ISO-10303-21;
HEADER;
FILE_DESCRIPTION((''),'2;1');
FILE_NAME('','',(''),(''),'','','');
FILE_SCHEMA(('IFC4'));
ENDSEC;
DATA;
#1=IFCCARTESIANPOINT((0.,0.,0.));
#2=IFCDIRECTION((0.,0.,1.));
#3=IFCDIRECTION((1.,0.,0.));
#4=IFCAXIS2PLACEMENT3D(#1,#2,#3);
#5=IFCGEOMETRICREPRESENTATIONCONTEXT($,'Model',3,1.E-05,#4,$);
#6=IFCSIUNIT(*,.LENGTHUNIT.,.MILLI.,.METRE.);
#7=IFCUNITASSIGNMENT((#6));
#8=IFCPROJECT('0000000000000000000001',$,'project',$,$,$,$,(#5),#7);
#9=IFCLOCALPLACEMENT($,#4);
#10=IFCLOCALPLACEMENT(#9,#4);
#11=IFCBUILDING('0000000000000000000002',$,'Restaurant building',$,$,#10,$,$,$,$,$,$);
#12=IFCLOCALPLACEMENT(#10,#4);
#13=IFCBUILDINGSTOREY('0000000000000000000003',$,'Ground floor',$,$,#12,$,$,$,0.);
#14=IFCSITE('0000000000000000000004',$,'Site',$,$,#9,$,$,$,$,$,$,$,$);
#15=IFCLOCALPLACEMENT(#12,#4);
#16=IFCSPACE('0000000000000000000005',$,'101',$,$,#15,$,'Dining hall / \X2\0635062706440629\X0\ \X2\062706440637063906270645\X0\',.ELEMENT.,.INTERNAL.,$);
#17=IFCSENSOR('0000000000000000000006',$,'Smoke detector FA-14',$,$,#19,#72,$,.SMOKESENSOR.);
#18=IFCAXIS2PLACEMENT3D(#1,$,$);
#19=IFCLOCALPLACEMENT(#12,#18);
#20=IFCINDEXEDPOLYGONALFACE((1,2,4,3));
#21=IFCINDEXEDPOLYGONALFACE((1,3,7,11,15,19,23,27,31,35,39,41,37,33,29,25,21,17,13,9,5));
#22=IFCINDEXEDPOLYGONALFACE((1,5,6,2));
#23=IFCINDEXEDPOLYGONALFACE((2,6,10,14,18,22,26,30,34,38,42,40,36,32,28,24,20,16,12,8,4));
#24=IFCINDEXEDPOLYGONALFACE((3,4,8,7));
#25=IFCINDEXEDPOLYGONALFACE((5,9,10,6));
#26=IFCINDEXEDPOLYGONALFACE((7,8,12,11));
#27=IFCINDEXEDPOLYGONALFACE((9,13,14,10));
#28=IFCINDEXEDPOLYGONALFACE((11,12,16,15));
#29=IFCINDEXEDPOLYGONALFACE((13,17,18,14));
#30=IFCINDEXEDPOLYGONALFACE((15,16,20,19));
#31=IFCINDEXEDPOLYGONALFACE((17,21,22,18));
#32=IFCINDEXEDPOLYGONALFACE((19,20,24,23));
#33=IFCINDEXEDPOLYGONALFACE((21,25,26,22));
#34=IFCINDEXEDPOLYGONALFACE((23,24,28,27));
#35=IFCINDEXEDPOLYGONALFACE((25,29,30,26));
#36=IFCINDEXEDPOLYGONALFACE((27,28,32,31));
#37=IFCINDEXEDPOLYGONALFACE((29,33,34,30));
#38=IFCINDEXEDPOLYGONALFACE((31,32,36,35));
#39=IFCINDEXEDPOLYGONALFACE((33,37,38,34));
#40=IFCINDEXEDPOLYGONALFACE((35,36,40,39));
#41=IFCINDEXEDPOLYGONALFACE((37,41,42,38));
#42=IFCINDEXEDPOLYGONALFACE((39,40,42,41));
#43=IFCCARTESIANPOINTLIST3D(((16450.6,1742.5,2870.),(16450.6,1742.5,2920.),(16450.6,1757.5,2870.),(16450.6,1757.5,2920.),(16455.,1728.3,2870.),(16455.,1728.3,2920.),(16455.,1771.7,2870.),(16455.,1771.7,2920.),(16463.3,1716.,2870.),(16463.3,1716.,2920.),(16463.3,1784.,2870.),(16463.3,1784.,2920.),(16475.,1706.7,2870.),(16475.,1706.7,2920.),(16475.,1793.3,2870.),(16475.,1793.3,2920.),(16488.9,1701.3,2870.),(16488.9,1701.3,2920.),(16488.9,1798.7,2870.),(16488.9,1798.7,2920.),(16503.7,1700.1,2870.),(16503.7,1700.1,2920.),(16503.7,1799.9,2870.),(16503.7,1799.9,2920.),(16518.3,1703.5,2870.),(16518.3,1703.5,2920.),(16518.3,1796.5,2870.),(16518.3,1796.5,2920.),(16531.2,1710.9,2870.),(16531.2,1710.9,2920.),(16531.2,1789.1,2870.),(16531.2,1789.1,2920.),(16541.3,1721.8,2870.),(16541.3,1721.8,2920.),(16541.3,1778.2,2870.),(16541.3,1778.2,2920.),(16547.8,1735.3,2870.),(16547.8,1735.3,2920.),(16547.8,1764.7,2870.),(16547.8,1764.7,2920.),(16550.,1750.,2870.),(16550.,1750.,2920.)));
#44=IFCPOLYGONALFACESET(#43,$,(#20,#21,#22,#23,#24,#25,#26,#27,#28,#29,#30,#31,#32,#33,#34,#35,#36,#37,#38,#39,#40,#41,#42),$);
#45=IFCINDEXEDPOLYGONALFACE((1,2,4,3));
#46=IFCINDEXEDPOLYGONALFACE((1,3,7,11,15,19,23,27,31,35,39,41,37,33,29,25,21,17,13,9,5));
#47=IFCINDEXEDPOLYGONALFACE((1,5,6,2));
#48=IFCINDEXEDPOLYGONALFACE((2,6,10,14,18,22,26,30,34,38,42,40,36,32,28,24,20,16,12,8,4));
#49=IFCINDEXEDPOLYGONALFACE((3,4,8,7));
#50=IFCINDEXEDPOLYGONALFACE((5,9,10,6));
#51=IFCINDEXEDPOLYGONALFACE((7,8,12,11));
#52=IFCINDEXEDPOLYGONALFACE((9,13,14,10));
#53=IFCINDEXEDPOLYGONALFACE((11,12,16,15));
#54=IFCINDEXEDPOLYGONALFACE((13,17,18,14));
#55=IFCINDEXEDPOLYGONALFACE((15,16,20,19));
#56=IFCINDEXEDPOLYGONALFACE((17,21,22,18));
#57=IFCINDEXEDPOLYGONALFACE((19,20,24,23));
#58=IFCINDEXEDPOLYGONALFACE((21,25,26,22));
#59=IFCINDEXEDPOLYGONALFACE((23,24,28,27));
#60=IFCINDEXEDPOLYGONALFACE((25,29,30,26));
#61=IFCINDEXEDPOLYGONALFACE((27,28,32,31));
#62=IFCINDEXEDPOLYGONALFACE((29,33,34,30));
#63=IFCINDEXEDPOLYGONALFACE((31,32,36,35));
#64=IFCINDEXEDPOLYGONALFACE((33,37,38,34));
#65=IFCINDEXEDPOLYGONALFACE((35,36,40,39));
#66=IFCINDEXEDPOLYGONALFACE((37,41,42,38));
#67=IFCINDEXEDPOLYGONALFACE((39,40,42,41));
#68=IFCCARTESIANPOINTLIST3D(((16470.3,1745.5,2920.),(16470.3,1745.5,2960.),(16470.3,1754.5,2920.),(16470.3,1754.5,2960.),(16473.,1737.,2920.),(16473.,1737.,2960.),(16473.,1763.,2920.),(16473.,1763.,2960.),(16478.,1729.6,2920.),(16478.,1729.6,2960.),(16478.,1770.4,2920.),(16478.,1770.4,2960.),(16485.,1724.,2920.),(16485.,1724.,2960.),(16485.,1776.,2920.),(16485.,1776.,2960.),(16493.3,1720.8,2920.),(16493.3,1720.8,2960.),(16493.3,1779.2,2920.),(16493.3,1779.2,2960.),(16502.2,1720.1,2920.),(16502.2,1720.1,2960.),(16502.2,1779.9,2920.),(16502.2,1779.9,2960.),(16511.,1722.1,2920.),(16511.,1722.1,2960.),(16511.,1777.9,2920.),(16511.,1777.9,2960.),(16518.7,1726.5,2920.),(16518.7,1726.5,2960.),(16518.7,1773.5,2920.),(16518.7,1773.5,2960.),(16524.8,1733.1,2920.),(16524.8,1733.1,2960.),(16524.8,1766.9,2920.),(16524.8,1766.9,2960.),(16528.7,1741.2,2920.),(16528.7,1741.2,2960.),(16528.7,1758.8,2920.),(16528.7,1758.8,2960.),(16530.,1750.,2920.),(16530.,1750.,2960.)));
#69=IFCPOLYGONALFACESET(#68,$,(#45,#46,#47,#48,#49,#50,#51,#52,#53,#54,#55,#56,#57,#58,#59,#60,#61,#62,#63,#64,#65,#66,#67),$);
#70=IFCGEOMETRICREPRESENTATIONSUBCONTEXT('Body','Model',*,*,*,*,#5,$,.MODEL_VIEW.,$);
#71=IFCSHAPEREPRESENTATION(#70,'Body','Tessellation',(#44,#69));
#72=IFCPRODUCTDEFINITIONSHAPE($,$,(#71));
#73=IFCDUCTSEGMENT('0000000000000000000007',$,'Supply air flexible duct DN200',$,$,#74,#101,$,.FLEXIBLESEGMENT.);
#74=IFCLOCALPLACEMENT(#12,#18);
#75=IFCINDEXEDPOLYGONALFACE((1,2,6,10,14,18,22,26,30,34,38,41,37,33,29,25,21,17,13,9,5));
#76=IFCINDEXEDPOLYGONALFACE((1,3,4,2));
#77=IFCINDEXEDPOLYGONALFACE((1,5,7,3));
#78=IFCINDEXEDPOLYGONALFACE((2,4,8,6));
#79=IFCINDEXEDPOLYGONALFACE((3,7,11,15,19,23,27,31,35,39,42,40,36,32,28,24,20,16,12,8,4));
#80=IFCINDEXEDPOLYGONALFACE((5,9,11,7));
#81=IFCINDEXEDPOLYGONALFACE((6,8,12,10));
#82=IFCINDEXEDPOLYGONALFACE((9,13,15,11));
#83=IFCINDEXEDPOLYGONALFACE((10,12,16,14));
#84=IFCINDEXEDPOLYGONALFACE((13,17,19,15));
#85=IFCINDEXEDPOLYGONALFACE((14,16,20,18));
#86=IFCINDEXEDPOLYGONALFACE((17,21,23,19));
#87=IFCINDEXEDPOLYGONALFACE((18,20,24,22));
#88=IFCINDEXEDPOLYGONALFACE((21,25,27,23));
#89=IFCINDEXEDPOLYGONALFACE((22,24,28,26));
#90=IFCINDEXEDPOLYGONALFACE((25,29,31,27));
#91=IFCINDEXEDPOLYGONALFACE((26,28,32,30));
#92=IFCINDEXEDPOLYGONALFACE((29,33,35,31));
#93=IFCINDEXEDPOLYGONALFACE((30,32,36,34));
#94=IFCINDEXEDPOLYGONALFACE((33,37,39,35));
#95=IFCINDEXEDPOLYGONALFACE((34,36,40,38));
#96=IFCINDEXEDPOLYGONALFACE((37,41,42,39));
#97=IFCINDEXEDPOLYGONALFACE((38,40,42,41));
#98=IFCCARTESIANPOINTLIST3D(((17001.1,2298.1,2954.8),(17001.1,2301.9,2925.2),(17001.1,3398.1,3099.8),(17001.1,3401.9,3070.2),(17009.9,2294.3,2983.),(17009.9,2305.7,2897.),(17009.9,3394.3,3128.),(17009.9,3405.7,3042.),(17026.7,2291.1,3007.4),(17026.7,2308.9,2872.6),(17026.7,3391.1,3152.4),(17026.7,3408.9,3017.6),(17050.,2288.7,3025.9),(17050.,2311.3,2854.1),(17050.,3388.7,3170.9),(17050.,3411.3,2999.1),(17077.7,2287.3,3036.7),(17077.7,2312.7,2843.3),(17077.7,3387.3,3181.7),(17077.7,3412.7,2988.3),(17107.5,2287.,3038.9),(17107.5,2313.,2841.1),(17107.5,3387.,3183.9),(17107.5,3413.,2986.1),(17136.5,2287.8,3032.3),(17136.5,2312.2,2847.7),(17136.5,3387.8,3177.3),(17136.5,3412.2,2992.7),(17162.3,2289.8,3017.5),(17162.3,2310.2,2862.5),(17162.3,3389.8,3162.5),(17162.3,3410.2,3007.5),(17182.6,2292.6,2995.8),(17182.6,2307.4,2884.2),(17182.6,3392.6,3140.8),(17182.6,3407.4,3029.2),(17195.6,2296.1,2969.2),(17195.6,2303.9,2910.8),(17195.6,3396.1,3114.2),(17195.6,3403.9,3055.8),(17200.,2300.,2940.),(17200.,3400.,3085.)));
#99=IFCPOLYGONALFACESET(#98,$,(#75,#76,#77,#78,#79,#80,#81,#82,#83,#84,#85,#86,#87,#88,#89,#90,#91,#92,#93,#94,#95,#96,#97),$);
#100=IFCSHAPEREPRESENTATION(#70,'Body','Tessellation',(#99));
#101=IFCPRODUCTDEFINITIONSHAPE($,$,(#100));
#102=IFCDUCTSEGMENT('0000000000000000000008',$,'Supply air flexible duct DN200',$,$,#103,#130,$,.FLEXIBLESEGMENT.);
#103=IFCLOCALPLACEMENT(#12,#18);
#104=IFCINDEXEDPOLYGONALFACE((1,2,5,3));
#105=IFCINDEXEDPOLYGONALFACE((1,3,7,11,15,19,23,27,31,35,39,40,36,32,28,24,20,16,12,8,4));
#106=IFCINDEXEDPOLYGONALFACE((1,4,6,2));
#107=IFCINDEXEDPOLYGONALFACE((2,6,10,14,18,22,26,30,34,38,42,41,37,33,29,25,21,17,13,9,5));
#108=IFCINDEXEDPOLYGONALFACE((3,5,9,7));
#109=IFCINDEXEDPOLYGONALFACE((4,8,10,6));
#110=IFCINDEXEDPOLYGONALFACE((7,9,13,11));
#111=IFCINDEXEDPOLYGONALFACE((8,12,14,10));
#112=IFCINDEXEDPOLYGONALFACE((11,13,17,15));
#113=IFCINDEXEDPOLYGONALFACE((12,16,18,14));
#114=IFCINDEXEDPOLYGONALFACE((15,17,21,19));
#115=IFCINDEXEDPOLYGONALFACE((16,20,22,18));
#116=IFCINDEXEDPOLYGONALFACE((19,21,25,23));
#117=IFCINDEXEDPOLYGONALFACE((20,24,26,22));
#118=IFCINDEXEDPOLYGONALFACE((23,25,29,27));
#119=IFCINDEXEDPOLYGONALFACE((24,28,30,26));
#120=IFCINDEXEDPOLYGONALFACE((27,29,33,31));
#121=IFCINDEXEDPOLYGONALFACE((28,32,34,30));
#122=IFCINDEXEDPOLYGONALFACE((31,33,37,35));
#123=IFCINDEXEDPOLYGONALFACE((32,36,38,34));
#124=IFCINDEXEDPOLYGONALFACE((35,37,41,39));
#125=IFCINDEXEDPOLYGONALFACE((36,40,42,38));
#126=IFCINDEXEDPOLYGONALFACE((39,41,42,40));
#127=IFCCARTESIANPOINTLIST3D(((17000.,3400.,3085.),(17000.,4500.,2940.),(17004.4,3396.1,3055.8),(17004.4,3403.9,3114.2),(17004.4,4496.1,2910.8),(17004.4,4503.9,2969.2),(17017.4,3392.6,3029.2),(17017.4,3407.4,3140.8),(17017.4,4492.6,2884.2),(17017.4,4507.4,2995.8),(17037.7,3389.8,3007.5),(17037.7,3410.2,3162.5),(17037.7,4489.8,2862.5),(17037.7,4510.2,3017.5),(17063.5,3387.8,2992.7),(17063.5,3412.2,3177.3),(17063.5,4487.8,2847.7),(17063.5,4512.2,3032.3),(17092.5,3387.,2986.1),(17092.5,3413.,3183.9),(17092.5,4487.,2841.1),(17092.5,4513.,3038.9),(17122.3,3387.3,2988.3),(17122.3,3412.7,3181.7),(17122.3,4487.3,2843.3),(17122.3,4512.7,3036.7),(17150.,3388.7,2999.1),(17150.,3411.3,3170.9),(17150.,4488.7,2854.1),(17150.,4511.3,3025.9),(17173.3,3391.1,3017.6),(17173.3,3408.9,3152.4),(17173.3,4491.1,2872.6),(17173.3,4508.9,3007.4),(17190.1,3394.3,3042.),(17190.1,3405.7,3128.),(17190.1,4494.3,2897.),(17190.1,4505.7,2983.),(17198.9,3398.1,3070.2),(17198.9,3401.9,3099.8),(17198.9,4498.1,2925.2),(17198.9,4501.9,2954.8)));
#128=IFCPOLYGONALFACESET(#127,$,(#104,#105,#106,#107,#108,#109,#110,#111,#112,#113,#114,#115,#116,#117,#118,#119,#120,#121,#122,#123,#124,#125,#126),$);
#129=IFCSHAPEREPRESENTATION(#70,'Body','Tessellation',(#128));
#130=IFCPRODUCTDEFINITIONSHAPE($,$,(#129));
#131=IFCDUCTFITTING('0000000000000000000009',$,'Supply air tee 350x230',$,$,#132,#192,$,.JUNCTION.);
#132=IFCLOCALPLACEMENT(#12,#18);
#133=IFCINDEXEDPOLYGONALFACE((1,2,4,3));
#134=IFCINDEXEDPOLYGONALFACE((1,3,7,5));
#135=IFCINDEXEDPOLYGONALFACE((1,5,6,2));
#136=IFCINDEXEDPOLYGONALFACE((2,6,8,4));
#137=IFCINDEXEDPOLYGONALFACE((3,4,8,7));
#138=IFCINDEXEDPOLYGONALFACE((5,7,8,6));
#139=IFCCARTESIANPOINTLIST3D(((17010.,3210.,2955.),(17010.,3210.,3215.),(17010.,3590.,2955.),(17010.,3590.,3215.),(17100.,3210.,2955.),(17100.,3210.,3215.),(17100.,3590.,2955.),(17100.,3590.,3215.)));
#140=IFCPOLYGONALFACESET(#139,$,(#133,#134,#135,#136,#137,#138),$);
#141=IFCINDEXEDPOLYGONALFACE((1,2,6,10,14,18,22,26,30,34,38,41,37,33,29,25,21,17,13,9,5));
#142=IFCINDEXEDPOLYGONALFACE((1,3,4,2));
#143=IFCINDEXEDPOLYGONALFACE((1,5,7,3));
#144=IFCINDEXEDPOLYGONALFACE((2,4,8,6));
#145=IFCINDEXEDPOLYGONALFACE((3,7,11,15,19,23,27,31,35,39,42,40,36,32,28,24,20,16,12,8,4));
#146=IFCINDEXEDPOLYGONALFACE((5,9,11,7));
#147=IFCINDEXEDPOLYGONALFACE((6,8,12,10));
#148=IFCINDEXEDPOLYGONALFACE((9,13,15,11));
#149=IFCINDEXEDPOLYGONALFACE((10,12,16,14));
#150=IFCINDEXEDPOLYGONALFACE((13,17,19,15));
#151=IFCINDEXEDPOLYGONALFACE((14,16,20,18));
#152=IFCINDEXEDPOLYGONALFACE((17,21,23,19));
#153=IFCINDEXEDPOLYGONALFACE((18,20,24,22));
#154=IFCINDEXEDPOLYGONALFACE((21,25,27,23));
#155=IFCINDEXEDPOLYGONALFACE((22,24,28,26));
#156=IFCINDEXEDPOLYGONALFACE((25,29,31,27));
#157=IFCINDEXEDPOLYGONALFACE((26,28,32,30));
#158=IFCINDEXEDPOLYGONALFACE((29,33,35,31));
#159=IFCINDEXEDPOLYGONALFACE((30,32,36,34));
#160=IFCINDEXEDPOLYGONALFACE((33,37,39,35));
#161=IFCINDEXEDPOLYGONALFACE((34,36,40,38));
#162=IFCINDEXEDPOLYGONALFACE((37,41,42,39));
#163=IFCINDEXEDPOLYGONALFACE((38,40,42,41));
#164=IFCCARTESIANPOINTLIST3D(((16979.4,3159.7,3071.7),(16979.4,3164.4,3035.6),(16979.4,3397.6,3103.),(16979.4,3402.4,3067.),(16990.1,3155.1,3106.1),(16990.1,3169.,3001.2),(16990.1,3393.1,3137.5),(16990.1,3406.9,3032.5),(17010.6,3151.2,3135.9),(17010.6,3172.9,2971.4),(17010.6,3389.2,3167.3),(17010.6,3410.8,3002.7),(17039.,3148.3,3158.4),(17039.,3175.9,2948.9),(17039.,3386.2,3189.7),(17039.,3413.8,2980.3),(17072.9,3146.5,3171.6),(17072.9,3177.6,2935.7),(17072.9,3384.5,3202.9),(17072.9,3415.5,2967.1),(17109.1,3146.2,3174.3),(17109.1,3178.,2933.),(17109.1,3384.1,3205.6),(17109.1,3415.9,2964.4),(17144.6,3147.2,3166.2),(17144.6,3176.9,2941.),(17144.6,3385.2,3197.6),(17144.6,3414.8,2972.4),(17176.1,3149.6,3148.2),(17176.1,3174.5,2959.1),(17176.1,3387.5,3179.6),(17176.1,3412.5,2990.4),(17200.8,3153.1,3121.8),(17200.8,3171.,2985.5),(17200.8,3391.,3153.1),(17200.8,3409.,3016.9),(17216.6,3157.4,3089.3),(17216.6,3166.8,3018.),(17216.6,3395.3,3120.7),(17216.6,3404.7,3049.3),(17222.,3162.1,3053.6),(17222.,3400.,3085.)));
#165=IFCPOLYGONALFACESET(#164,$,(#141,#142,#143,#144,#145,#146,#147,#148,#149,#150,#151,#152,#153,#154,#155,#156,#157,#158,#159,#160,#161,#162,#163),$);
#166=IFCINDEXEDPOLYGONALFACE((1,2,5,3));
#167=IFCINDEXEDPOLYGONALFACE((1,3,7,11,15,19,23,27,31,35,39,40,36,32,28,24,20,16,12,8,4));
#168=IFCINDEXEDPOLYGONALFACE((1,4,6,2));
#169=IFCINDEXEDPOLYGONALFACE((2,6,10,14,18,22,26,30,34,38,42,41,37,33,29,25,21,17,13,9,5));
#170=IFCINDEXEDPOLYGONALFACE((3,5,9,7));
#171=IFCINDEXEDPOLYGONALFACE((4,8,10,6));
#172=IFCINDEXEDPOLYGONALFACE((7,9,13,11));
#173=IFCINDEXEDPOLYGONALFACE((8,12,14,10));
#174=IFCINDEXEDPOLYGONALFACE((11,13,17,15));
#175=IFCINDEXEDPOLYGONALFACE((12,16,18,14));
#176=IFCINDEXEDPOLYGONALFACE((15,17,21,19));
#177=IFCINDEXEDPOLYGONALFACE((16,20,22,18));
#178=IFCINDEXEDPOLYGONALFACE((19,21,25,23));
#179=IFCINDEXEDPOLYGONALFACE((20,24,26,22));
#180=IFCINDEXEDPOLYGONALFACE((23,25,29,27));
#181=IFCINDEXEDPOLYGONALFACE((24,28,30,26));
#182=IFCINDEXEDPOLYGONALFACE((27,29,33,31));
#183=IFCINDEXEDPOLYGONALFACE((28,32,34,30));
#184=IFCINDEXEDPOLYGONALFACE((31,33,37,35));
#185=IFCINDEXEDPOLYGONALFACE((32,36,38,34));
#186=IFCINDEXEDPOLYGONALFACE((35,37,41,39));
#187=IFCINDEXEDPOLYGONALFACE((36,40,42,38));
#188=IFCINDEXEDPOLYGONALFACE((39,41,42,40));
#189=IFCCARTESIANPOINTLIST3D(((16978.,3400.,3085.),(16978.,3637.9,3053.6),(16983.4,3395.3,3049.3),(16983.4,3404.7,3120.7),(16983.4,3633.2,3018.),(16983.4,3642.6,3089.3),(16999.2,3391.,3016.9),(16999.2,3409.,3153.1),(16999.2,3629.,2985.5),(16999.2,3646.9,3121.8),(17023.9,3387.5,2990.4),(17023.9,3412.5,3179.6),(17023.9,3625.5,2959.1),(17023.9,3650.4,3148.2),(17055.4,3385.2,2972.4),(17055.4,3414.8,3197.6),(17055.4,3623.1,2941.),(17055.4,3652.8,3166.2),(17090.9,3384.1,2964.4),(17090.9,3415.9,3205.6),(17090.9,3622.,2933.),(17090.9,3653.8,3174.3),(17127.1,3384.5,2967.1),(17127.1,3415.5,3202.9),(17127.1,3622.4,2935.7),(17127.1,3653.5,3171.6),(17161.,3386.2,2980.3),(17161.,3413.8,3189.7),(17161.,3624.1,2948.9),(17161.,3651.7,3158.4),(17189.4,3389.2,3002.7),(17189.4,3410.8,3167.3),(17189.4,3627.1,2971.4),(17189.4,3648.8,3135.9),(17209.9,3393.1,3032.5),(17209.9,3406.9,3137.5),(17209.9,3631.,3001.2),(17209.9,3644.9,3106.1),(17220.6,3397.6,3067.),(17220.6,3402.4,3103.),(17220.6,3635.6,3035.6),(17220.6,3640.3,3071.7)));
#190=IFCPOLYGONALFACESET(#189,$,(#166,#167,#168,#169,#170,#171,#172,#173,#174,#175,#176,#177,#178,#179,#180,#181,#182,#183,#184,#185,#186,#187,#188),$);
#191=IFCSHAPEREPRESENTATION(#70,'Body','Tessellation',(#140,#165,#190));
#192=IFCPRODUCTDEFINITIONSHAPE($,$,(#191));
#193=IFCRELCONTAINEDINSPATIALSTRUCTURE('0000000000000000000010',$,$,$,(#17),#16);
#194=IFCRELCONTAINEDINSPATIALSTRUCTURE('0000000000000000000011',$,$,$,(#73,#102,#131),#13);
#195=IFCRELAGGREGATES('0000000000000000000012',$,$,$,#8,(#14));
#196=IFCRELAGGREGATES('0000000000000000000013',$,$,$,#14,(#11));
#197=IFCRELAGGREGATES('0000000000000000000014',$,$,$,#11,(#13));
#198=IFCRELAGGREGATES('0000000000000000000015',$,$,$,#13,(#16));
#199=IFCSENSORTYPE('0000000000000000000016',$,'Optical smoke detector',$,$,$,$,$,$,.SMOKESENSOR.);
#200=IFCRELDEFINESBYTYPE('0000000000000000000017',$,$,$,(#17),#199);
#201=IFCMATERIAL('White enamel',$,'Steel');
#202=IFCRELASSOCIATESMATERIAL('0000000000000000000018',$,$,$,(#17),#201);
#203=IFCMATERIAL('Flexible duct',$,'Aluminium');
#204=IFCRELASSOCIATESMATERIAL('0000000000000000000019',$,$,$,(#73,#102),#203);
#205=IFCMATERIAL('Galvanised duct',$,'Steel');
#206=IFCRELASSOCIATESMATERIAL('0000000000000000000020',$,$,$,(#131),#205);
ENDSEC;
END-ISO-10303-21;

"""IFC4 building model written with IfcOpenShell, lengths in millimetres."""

from ifc_helpers import new_model, si_unit, frame, origin, origin_with_axes, origin_2d, place, context, subcontext, project, spatial, rectangle, circle, extrude, source, transform, mapped, material, type_object, type_shapes, element, save


model = new_model("IFC4")

# Units and contexts
model_context = context("Model", 3, precision=1e-05, world=origin_with_axes())
body_context = subcontext(model_context, "Body", "Model", "MODEL_VIEW")
ifc_project = project(units=[si_unit("LENGTHUNIT", "METRE", prefix="MILLI")], contexts=[model_context])

# Site, building, storey
site_placement = place(None, origin_with_axes())
site = spatial("IfcSite", under=ifc_project, at=site_placement, Name="Site")
building_placement = place(site_placement, origin_with_axes())
building = spatial("IfcBuilding", under=site, at=building_placement, Name="Restaurant building")
storey_placement = place(building_placement, origin_with_axes())
storey = spatial("IfcBuildingStorey", under=building, at=storey_placement, Name="Ground floor", Elevation=0.0)

# Shared definitions
ifc_material_1 = material(Name="White enamel", Category="Steel")

# Shared definitions
space_placement = place(storey_placement, origin_with_axes())
space = spatial("IfcSpace", under=storey, at=space_placement, Name="101", LongName="Dining hall / صالة الطعام", CompositionType="ELEMENT", PredefinedType="INTERNAL")

# Sensor
sensor_type = type_object("IfcSensorType", Name="Optical smoke detector", PredefinedType="SMOKESENSOR")
shared_shape_1 = source(origin(), body_context, "Body", "SweptSolid", [
    extrude(circle(Radius=50.0, at=origin_2d()), frame((0.0, 0.0, -90.0)), (0.0, 0.0, 1.0), 50.0),
    extrude(circle(Radius=30.0, at=origin_2d()), frame((0.0, 0.0, -40.0)), (0.0, 0.0, 1.0), 40.0),
])
type_shapes(sensor_type, [shared_shape_1])
sensor_placement = place(storey_placement, frame((16500.0, 1750.0, 2960.0)))
element("IfcSensor", 1, at=sensor_placement, inside=space, type_object=sensor_type, material=ifc_material_1, Name="Smoke detector FA-14", PredefinedType="SMOKESENSOR", context=body_context, shape_type="MappedRepresentation", body=[
    mapped(shared_shape_1, transform((0.0, 0.0, 0.0))),
])

# Duct segments
ifc_material_2 = material(Name="Flexible duct", Category="Aluminium")
duct_segment_1_placement = place(storey_placement, frame((17100.0, 3400.0, 3085.0)))
element("IfcDuctSegment", 2, at=duct_segment_1_placement, inside=storey, material=ifc_material_2, Name="Supply air flexible duct DN200", PredefinedType="FLEXIBLESEGMENT", context=body_context, shape_type="SweptSolid", body=[
    extrude(circle(Radius=100.0, at=origin_2d()), frame((0.0, 0.0, 0.0), z_axis=(0.0, -0.991424, -0.130688), x_axis=(1.0, 0.0, 0.0)), (0.0, 0.0, 1.0), 1109.5),
])
duct_segment_2_placement = place(storey_placement, frame((17100.0, 3400.0, 3085.0)))
element("IfcDuctSegment", 3, at=duct_segment_2_placement, inside=storey, material=ifc_material_2, Name="Supply air flexible duct DN200", PredefinedType="FLEXIBLESEGMENT", context=body_context, shape_type="SweptSolid", body=[
    extrude(circle(Radius=100.0, at=origin_2d()), frame((0.0, 0.0, 0.0), z_axis=(0.0, 0.991424, -0.130688), x_axis=(-1.0, 0.0, 0.0)), (0.0, 0.0, 1.0), 1109.5),
])

# Duct fitting
ifc_material_3 = material(Name="Galvanised duct", Category="Steel")
duct_fitting_placement = place(storey_placement, frame((17100.0, 3400.0, 3085.0)))
element("IfcDuctFitting", 4, at=duct_fitting_placement, inside=storey, material=ifc_material_3, Name="Supply air tee 350x230", PredefinedType="JUNCTION", context=body_context, shape_type="SweptSolid", body=[
    extrude(rectangle(XDim=380.0, YDim=260.0, at=origin_2d()), frame((0.0, 0.0, 0.0), z_axis=(-1.0, 0.0, 0.0), x_axis=(0.0, -1.0, 0.0)), (0.0, 0.0, 1.0), 90.0),
    extrude(circle(Radius=122.0, at=origin_2d()), frame((0.0, 0.0, 0.0), z_axis=(0.0, -0.991424, -0.130688), x_axis=(1.0, 0.0, 0.0)), (0.0, 0.0, 1.0), 240.0),
    extrude(circle(Radius=122.0, at=origin_2d()), frame((0.0, 0.0, 0.0), z_axis=(0.0, 0.991424, -0.130688), x_axis=(-1.0, 0.0, 0.0)), (0.0, 0.0, 1.0), 240.0),
])

save(model, "model.ifc")
